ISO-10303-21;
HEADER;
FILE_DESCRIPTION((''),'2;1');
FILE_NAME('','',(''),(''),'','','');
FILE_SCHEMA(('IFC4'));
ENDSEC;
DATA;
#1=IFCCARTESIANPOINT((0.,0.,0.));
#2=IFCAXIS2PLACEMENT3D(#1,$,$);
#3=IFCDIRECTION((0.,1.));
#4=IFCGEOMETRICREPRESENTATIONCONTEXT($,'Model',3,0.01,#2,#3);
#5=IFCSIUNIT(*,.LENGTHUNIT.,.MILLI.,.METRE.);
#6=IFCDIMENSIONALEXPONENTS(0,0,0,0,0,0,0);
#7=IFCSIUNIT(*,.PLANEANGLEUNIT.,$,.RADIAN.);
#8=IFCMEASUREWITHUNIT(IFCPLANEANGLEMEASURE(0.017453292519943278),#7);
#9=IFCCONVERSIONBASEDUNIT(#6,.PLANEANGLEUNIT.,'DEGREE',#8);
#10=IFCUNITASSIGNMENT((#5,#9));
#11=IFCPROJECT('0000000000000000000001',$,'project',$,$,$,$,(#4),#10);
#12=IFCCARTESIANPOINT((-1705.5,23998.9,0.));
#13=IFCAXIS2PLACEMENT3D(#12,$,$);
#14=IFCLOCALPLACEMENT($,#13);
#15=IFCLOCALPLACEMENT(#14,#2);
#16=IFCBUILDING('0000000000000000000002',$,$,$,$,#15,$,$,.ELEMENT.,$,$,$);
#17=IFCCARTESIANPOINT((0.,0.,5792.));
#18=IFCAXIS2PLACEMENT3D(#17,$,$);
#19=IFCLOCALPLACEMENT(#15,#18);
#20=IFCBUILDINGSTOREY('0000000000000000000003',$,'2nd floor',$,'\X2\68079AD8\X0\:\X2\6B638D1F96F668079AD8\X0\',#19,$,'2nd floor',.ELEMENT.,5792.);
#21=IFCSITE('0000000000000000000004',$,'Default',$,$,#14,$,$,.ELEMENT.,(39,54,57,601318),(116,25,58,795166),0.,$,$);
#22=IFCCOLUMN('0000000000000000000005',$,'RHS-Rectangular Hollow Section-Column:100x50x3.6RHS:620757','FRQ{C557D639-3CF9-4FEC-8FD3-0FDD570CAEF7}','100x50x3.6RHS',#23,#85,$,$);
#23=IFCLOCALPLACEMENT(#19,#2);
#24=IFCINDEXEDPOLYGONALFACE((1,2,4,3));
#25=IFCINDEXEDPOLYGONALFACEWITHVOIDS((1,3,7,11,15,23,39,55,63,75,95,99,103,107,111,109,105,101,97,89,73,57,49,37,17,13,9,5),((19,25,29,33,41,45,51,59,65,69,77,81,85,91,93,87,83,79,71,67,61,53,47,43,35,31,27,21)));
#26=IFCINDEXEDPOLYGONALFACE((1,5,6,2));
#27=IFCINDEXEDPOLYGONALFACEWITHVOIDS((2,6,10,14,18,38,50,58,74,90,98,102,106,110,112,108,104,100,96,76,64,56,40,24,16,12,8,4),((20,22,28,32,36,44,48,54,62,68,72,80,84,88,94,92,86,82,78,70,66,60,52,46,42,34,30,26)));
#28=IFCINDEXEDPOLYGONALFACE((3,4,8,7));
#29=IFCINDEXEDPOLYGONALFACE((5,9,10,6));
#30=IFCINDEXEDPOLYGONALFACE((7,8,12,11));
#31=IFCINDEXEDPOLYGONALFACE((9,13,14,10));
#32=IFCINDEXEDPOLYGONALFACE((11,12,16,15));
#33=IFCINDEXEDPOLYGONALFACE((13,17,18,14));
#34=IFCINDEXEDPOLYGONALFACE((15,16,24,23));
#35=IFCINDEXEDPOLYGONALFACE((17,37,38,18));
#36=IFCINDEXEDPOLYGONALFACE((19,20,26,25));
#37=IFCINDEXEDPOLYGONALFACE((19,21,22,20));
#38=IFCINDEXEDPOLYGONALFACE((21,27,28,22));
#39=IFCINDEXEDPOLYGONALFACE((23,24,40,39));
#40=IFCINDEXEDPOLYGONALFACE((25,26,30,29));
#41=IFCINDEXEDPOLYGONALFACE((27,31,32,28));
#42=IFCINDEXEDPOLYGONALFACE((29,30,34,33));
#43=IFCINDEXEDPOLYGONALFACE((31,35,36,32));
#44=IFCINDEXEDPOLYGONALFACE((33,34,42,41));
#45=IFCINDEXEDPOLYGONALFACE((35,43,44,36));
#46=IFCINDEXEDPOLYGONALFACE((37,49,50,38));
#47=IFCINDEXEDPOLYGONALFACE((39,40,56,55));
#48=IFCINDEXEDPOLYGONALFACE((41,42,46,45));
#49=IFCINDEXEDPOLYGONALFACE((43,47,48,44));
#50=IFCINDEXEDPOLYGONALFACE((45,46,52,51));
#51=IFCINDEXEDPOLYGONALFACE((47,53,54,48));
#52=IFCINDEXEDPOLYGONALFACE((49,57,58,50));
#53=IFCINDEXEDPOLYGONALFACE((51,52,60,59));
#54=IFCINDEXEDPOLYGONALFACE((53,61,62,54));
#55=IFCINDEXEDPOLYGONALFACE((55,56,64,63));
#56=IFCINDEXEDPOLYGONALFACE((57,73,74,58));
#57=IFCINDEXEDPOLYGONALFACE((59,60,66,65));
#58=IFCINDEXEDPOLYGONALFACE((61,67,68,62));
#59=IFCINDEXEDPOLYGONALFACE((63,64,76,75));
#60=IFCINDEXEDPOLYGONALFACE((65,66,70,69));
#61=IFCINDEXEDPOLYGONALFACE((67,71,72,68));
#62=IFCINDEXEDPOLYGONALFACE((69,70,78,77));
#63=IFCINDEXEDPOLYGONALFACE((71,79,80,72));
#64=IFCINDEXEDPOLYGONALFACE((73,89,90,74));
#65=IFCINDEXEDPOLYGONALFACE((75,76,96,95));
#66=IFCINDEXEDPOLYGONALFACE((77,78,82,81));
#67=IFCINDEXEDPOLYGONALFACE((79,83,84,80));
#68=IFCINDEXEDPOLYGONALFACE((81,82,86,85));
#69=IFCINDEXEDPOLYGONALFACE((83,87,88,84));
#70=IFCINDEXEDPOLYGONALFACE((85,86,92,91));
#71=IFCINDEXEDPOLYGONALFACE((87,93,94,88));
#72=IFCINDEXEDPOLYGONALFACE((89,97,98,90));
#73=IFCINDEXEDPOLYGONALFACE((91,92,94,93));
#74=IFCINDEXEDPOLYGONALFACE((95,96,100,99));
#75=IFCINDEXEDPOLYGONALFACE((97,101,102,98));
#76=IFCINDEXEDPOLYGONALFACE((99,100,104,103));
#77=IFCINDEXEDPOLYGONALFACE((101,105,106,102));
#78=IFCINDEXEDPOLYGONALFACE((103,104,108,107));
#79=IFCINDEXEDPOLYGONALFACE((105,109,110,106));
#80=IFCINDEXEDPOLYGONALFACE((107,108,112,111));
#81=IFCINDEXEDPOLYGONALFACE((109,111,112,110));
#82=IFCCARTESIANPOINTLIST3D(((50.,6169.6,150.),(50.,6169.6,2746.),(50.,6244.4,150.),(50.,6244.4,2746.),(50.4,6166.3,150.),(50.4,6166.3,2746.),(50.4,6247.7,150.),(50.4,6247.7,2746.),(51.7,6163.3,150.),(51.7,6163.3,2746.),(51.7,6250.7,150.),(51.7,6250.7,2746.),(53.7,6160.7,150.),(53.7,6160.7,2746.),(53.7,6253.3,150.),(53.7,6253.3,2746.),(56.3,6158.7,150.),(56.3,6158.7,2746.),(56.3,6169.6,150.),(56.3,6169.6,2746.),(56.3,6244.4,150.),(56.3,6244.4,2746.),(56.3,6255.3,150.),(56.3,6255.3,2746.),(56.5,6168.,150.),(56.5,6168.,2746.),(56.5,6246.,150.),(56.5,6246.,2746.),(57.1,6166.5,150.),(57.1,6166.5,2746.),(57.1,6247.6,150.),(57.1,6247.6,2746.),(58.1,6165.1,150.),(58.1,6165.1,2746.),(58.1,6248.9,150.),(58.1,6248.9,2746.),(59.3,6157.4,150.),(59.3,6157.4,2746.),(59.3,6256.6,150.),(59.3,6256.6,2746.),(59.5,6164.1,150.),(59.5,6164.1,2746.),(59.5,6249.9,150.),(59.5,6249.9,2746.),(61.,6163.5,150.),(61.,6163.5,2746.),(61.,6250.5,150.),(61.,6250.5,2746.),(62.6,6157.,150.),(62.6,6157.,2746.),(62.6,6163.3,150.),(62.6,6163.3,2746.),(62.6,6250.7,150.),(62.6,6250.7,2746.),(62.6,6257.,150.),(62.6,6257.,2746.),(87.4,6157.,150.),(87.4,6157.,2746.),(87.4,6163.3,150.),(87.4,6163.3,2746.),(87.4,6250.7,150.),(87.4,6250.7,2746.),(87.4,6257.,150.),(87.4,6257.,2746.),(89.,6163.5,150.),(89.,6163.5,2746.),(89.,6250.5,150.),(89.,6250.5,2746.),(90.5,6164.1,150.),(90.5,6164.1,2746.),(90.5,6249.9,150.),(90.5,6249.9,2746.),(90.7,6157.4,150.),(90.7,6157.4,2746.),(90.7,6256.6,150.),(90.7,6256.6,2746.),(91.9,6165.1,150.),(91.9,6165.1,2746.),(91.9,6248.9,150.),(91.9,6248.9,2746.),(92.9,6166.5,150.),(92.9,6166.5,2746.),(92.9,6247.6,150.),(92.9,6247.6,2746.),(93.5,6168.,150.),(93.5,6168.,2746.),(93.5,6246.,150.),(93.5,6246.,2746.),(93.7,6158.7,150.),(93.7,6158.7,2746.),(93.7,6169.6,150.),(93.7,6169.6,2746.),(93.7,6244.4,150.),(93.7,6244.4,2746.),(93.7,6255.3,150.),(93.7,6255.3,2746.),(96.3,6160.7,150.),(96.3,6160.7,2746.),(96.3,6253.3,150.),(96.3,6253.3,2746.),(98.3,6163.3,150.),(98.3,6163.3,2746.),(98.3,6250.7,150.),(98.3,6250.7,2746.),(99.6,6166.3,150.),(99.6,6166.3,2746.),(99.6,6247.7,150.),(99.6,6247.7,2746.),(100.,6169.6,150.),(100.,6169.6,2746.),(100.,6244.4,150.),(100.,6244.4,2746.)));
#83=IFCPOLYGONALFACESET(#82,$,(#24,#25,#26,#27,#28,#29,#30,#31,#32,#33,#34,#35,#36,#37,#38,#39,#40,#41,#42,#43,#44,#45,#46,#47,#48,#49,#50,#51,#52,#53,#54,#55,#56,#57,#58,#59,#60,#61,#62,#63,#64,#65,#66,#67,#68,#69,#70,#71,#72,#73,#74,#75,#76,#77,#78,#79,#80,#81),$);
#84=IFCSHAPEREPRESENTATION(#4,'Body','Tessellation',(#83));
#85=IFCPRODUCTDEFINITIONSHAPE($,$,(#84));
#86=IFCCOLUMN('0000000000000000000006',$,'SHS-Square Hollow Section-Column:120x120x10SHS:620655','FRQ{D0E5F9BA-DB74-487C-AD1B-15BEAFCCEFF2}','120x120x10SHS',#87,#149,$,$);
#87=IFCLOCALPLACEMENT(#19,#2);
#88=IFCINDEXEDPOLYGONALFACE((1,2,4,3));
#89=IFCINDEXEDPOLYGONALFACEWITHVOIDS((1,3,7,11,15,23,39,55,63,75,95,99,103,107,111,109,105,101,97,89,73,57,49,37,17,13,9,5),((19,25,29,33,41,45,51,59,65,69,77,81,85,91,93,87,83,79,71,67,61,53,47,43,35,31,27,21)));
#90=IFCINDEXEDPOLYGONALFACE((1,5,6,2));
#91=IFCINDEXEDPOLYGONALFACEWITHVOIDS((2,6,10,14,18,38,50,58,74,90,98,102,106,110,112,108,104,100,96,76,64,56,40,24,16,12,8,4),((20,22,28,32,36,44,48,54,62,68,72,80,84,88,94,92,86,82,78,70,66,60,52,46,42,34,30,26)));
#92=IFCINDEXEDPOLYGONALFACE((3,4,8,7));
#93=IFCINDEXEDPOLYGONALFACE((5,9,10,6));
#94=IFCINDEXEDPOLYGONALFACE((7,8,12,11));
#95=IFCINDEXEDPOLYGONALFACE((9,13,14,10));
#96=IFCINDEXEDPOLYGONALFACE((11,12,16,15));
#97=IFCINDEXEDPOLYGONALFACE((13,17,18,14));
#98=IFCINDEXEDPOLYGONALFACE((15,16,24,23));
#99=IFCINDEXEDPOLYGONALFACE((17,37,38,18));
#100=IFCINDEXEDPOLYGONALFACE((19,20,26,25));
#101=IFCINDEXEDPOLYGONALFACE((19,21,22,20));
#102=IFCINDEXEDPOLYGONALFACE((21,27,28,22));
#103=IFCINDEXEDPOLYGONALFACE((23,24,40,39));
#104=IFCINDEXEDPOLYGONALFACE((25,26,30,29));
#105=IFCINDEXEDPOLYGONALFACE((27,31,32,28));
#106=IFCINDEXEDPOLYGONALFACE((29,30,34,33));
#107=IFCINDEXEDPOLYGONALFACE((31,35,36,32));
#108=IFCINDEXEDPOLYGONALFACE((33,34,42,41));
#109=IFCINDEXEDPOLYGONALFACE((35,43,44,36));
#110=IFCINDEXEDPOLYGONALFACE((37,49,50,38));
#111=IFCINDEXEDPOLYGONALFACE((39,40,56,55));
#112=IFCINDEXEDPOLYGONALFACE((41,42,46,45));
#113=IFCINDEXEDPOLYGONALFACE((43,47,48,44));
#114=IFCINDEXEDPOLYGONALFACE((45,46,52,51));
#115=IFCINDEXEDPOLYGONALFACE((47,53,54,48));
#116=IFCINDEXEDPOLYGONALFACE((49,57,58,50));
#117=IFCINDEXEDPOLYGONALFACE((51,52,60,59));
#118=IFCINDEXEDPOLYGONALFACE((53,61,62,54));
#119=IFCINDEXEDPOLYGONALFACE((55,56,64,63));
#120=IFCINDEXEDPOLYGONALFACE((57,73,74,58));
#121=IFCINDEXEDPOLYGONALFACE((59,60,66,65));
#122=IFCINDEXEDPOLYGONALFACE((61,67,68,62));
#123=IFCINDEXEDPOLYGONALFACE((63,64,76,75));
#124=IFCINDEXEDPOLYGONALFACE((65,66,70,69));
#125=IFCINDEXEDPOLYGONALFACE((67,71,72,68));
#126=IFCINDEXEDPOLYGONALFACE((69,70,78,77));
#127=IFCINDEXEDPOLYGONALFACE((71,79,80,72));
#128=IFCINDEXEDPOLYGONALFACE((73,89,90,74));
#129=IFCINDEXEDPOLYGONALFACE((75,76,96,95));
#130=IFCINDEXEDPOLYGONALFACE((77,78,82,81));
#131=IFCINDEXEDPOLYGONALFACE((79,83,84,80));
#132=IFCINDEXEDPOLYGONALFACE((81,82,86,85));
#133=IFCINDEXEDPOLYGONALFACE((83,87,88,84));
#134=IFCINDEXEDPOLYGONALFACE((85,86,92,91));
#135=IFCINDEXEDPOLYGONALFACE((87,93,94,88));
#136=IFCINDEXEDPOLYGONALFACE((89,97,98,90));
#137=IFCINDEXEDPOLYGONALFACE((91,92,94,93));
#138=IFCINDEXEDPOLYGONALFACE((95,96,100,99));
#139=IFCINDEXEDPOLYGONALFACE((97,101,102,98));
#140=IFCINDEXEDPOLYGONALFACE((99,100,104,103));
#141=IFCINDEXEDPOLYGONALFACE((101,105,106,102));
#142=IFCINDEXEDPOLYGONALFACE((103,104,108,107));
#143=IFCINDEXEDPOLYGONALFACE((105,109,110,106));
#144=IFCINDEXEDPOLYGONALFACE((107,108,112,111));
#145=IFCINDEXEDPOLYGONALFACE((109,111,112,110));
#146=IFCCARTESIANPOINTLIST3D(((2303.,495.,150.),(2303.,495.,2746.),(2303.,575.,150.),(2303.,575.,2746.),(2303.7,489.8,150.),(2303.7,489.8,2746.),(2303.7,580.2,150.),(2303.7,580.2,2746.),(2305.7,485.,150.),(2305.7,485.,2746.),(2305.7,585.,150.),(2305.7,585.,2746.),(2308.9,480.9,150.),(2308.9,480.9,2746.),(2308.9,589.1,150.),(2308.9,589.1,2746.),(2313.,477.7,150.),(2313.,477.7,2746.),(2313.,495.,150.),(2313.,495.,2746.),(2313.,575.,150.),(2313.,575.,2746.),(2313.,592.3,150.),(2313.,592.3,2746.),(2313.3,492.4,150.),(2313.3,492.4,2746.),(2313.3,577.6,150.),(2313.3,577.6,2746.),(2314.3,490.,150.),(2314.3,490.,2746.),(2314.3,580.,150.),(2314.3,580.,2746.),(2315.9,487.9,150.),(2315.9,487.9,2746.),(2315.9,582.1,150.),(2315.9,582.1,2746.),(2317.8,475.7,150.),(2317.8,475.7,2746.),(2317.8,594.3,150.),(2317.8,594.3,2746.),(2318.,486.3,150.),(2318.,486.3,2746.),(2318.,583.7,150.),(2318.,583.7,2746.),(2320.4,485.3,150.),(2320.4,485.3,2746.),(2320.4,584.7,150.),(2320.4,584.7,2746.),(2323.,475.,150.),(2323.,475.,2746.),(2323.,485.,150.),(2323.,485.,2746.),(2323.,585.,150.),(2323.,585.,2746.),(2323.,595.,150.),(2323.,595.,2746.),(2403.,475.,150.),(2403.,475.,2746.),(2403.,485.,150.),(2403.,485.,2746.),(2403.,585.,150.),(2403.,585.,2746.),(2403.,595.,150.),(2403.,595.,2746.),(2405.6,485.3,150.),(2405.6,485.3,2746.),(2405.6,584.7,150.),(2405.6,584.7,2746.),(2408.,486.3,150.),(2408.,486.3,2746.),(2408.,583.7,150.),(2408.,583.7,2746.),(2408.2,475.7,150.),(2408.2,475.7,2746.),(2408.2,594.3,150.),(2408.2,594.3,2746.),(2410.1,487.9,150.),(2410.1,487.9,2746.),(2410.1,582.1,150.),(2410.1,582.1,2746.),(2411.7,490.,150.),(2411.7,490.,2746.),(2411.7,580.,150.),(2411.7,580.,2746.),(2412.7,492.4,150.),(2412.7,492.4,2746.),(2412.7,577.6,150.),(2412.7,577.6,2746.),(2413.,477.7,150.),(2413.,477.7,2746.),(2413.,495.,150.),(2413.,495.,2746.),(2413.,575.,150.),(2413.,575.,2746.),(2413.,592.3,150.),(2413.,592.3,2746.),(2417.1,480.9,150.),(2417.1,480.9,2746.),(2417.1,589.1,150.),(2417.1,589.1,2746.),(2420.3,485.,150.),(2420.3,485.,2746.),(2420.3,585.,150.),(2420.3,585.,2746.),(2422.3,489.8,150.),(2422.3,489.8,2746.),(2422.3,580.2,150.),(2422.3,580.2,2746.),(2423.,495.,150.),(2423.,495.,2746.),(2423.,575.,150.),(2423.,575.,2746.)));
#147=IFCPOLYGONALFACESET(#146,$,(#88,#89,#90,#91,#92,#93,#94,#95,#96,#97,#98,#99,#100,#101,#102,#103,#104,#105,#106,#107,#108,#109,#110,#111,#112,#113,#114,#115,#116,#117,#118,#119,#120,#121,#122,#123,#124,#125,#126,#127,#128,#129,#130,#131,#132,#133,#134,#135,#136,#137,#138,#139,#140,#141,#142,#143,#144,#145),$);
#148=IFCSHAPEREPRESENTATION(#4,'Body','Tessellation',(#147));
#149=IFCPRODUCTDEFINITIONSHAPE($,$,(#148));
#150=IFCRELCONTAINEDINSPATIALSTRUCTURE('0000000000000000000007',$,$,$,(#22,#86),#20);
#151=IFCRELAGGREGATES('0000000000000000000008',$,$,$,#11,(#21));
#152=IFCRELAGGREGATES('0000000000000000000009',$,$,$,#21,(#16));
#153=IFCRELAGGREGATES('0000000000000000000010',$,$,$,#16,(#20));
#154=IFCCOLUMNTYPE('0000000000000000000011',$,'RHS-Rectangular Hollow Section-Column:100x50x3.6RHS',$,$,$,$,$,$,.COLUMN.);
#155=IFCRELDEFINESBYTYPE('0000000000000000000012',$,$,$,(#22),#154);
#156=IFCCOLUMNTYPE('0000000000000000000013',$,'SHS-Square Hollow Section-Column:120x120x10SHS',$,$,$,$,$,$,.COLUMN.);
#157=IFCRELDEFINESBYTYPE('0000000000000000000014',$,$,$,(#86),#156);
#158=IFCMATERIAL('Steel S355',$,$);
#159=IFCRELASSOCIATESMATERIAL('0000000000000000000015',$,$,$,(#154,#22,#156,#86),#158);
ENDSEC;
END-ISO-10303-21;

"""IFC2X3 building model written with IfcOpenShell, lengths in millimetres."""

from ifc_helpers import new_model, entity, si_unit, converted_unit, direction, frame, origin, origin_2d, place, context, project, spatial, hollow_rectangle, extrude, clip, halfspace, material, type_object, element, save


model = new_model("IFC2X3")

# Units and contexts
model_context = context("Model", 3, precision=0.01, world=origin(), true_north=direction((0.0, 1.0)))
ifc_project = project(units=[si_unit("LENGTHUNIT", "METRE", prefix="MILLI"), converted_unit("PLANEANGLEUNIT", "DEGREE", entity("IfcPlaneAngleMeasure", 0.017453292519943278), si_unit("PLANEANGLEUNIT", "RADIAN"), dimensions=[0, 0, 0, 0, 0, 0, 0])], contexts=[model_context])

# Site, building, storey
site_placement = place(None, frame((-1705.5, 23998.9, 0.0)))
site = spatial("IfcSite", under=ifc_project, at=site_placement, Name="Default", CompositionType="ELEMENT", RefLatitude=(39, 54, 57, 601318), RefLongitude=(116, 25, 58, 795166), RefElevation=0.0)
building_placement = place(site_placement, origin())
building = spatial("IfcBuilding", under=site, at=building_placement, CompositionType="ELEMENT")
storey_placement = place(building_placement, frame((0.0, 0.0, 5792.0)))
storey = spatial("IfcBuildingStorey", under=building, at=storey_placement, Name="2nd floor", ObjectType="标高:正负零标高", LongName="2nd floor", CompositionType="ELEMENT", Elevation=5792.0)

# Shared definitions
ifc_material_1 = material(Name="Steel S355")

# Columns
column_type_1 = type_object("IfcColumnType", Name="RHS-Rectangular Hollow Section-Column:100x50x3.6RHS", PredefinedType="COLUMN", material=ifc_material_1)
column_1_placement = place(storey_placement, frame((75.0, 6207.0, 2746.0), z_axis=(0.0, 0.0, 1.0), x_axis=(-1.0, 0.0, 0.0)))
element("IfcColumn", 1, at=column_1_placement, inside=storey, type_object=column_type_1, material=ifc_material_1, Name="RHS-Rectangular Hollow Section-Column:100x50x3.6RHS:620757", Description="FRQ{C557D639-3CF9-4FEC-8FD3-0FDD570CAEF7}", ObjectType="100x50x3.6RHS", context=model_context, shape_type="Clipping", body=[
    clip(extrude(hollow_rectangle(XDim=50.0, YDim=100.0, WallThickness=6.3, InnerFilletRadius=6.3, OuterFilletRadius=12.6, at=origin_2d()), origin(), (0.0, 0.0, -1.0), 2651.9), halfspace(frame((75.0, 6207.0, -2596.0), z_axis=(0.0, 0.0, 1.0), x_axis=(-1.0, 0.0, 0.0)), True)),
])
column_type_2 = type_object("IfcColumnType", Name="SHS-Square Hollow Section-Column:120x120x10SHS", PredefinedType="COLUMN", material=ifc_material_1)
column_2_placement = place(storey_placement, frame((2363.0, 535.0, 2746.0), z_axis=(0.0, 0.0, 1.0), x_axis=(0.0, -1.0, 0.0)))
element("IfcColumn", 2, at=column_2_placement, inside=storey, type_object=column_type_2, material=ifc_material_1, Name="SHS-Square Hollow Section-Column:120x120x10SHS:620655", Description="FRQ{D0E5F9BA-DB74-487C-AD1B-15BEAFCCEFF2}", ObjectType="120x120x10SHS", context=model_context, shape_type="Clipping", body=[
    clip(extrude(hollow_rectangle(XDim=120.0, YDim=120.0, WallThickness=10.0, InnerFilletRadius=10.0, OuterFilletRadius=20.0, at=origin_2d()), origin(), (0.0, 0.0, -1.0), 2680.9), halfspace(frame((535.0, -2363.0, -2596.0), z_axis=(0.0, 0.0, 1.0), x_axis=(0.0, 1.0, 0.0)), True)),
])

save(model, "model.ifc")
